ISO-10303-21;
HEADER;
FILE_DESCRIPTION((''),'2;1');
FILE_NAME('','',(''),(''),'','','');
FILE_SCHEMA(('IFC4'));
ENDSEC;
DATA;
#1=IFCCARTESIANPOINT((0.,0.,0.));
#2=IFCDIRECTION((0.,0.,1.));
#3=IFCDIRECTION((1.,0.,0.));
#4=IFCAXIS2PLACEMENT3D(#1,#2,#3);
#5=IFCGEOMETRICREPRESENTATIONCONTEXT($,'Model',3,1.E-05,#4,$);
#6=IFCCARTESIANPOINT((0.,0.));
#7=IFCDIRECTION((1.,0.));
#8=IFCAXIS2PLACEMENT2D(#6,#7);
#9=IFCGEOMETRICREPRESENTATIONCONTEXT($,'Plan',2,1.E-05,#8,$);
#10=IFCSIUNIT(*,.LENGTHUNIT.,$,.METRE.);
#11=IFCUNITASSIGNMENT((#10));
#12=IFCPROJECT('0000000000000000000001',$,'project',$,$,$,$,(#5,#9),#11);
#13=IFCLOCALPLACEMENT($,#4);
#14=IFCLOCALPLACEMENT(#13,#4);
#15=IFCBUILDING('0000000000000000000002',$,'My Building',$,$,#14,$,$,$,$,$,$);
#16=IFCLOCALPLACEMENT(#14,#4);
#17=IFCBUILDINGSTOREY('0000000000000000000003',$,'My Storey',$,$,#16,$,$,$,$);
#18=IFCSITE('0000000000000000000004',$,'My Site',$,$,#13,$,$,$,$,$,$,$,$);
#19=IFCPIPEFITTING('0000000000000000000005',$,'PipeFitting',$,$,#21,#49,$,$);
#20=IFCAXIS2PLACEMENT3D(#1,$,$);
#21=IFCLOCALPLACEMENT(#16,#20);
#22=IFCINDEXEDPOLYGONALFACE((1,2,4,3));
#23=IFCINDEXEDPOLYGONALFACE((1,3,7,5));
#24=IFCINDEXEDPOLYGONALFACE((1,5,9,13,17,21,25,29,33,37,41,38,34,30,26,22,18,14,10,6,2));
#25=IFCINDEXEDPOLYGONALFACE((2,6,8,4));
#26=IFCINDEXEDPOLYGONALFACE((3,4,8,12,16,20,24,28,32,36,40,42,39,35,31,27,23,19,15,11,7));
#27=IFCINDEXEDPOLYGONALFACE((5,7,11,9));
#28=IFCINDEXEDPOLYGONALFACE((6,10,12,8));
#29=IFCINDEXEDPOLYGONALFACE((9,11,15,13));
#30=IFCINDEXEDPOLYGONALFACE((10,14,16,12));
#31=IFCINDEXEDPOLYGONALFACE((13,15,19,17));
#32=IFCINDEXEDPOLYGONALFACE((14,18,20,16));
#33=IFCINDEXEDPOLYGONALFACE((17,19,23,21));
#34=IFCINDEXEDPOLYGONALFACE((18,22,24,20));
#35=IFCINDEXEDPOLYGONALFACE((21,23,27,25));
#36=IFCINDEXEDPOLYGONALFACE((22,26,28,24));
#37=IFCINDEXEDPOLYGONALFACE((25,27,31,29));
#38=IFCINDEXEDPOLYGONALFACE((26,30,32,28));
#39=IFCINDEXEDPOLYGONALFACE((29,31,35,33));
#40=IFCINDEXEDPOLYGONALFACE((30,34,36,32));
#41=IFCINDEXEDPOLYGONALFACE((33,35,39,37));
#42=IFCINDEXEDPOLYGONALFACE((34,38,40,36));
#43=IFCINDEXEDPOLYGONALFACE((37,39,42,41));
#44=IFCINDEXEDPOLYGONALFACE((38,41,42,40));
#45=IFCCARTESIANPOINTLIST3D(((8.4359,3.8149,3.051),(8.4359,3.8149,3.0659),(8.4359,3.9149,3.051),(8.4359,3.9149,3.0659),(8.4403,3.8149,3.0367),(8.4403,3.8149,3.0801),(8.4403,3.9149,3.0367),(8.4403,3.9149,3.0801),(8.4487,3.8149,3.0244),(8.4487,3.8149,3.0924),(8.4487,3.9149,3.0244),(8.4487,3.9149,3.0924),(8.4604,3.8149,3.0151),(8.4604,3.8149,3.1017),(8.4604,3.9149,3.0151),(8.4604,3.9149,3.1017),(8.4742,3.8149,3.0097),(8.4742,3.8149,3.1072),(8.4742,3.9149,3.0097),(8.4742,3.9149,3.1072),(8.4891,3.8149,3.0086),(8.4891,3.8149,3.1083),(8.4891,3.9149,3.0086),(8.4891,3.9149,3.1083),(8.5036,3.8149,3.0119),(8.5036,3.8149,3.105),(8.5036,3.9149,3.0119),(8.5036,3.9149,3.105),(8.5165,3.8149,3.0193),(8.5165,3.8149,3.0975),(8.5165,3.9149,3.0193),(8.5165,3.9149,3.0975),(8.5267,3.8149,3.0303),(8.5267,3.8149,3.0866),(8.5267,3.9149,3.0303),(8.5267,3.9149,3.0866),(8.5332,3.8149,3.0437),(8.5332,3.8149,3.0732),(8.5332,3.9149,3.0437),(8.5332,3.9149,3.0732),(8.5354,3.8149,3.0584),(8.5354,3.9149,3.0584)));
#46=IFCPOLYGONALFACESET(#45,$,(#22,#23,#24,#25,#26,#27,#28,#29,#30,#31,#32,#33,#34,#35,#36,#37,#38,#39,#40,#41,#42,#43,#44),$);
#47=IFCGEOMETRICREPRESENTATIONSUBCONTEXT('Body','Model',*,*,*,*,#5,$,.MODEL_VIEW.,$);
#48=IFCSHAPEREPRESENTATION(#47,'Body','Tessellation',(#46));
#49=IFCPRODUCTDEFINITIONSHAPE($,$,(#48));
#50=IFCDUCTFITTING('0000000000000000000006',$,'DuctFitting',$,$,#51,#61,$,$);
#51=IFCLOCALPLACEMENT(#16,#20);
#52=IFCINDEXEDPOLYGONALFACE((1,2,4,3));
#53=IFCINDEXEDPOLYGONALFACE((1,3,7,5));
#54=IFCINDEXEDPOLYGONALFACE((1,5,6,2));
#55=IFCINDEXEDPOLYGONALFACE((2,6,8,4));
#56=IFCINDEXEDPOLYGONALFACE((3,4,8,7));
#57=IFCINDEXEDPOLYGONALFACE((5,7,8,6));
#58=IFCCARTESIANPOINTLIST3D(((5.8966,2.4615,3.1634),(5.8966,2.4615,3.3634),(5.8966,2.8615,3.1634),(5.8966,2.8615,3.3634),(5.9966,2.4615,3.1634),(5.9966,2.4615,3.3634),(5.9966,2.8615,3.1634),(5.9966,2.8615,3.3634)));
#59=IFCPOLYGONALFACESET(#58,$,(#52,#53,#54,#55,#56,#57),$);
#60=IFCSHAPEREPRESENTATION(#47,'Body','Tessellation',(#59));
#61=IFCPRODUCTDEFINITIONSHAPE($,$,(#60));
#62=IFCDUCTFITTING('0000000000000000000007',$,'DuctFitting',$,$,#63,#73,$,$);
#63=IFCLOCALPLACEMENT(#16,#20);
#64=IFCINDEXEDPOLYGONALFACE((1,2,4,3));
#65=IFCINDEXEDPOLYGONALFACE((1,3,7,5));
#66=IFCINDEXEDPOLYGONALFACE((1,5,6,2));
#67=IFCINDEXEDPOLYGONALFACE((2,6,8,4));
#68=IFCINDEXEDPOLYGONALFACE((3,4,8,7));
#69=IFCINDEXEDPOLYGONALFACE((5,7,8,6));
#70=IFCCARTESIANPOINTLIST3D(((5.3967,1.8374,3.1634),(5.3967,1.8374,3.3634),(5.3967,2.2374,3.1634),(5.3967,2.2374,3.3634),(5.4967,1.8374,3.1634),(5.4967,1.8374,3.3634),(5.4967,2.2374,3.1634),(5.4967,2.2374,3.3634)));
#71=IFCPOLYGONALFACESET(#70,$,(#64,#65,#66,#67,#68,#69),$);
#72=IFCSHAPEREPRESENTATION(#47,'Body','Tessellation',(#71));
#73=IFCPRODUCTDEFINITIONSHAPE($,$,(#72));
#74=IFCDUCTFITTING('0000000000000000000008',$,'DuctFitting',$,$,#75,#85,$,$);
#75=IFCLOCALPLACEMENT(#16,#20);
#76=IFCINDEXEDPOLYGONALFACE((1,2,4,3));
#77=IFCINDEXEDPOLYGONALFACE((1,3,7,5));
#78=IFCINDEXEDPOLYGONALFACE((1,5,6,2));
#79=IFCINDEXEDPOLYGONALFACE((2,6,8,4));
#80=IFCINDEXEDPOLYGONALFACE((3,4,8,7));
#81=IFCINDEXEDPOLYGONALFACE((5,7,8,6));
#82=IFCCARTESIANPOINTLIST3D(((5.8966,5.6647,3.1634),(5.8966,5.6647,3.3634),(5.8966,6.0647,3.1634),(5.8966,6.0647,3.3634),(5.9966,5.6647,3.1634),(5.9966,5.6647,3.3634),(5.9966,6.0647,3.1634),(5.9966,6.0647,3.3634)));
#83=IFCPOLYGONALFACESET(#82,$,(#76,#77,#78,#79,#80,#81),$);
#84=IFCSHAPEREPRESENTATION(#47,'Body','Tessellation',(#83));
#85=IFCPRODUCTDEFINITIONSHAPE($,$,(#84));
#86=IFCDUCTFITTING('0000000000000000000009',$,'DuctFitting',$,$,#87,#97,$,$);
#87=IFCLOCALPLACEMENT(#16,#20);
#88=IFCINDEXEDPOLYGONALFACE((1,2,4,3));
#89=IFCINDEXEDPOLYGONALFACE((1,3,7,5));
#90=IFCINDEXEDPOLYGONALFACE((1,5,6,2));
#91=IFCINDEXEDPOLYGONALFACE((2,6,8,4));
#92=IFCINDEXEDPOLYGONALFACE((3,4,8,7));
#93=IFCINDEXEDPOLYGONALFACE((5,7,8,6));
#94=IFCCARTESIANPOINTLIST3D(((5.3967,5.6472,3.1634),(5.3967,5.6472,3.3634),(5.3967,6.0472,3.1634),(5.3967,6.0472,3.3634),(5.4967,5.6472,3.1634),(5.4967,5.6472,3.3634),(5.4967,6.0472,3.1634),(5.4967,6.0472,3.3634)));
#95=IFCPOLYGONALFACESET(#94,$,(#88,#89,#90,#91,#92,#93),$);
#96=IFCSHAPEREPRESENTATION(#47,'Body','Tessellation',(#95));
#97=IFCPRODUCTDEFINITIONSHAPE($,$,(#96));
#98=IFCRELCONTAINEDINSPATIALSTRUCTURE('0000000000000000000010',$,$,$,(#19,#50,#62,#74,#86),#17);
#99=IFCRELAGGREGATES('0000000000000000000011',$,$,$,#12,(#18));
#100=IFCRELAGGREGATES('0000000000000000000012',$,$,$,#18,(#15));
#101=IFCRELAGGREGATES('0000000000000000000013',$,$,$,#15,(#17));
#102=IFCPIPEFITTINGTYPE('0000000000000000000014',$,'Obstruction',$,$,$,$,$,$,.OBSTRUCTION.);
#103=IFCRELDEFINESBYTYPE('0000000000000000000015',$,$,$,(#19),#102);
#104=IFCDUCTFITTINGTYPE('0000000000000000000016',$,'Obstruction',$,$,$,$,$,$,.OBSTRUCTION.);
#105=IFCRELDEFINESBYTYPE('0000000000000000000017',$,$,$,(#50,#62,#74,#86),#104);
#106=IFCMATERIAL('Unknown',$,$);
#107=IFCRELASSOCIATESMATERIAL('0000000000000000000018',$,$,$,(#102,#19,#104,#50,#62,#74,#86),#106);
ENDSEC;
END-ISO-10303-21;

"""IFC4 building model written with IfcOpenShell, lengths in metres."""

from ifc_helpers import new_model, si_unit, frame, origin_with_axes, origin_2d_with_axis, place, context, subcontext, project, spatial, rectangle, circle, extrude, material, material_profile, profile_set, profile_usage, type_object, element, save


model = new_model("IFC4")

# Units and contexts
model_context = context("Model", 3, precision=1e-05, world=origin_with_axes())
plan_context = context("Plan", 2, precision=1e-05, world=origin_2d_with_axis())
body_context_1 = subcontext(model_context, "Body", "Model", "MODEL_VIEW")
ifc_project = project(units=[si_unit("LENGTHUNIT", "METRE")], contexts=[model_context, plan_context])

# Site, building, storey
site_placement = place(None, origin_with_axes())
site = spatial("IfcSite", under=ifc_project, at=site_placement, Name="My Site")
building_placement = place(site_placement, origin_with_axes())
building = spatial("IfcBuilding", under=site, at=building_placement, Name="My Building")
storey_placement = place(building_placement, origin_with_axes())
storey = spatial("IfcBuildingStorey", under=building, at=storey_placement, Name="My Storey")

# Shared definitions
ifc_material = material(Name="Unknown")

# Pipe fitting
ifc_material_profile_1 = material_profile(ifc_material, circle(Radius=0.05))
ifc_profile_set_1 = profile_set([ifc_material_profile_1])
pipe_fitting_type = type_object("IfcPipeFittingType", Name="Obstruction", PredefinedType="OBSTRUCTION", material=ifc_profile_set_1)
ifc_profile_usage_1 = profile_usage(ifc_profile_set_1, cardinal=5)
pipe_fitting_1_placement = place(storey_placement, frame((8.4854, 3.9149, 3.0584), z_axis=(0.0, -1.0, 0.000001), x_axis=(1.0, 0.0, 0.0)))
element("IfcPipeFitting", 1, at=pipe_fitting_1_placement, inside=storey, type_object=pipe_fitting_type, material=ifc_profile_usage_1, Name="PipeFitting", context=body_context_1, shape_type="SweptSolid", body=[
    extrude(circle(Radius=0.05), origin_with_axes(), (0.0, 0.0, 1.0), 0.1),
])

# Duct fittings
ifc_material_profile_2 = material_profile(ifc_material, rectangle(XDim=0.4, YDim=0.2))
ifc_profile_set_2 = profile_set([ifc_material_profile_2])
ifc_profile_usage_2 = profile_usage(ifc_profile_set_2, cardinal=5)
duct_fitting_type = type_object("IfcDuctFittingType", Name="Obstruction", PredefinedType="OBSTRUCTION", material=ifc_profile_set_2)
duct_fitting_1_placement = place(storey_placement, frame((5.9966, 2.6615, 3.2634), z_axis=(-1.0, 0.0, 0.0), x_axis=(0.0, -1.0, 0.0)))
element("IfcDuctFitting", 2, at=duct_fitting_1_placement, inside=storey, type_object=duct_fitting_type, material=ifc_profile_usage_2, Name="DuctFitting", context=body_context_1, shape_type="SweptSolid", body=[
    extrude(rectangle(XDim=0.4, YDim=0.2), origin_with_axes(), (0.0, 0.0, 1.0), 0.1),
])
ifc_profile_usage_3 = profile_usage(ifc_profile_set_2, cardinal=5)
duct_fitting_2_placement = place(storey_placement, frame((5.4967, 2.0374, 3.2634), z_axis=(-1.0, 0.0, 0.0), x_axis=(0.0, -1.0, 0.0)))
element("IfcDuctFitting", 3, at=duct_fitting_2_placement, inside=storey, type_object=duct_fitting_type, material=ifc_profile_usage_3, Name="DuctFitting", context=body_context_1, shape_type="SweptSolid", body=[
    extrude(rectangle(XDim=0.4, YDim=0.2), origin_with_axes(), (0.0, 0.0, 1.0), 0.1),
])
ifc_profile_usage_4 = profile_usage(ifc_profile_set_2, cardinal=5)
duct_fitting_3_placement = place(storey_placement, frame((5.9966, 5.8647, 3.2634), z_axis=(-1.0, 0.0, 0.0), x_axis=(0.0, -1.0, 0.0)))
element("IfcDuctFitting", 4, at=duct_fitting_3_placement, inside=storey, type_object=duct_fitting_type, material=ifc_profile_usage_4, Name="DuctFitting", context=body_context_1, shape_type="SweptSolid", body=[
    extrude(rectangle(XDim=0.4, YDim=0.2), origin_with_axes(), (0.0, 0.0, 1.0), 0.1),
])
ifc_profile_usage_5 = profile_usage(ifc_profile_set_2, cardinal=5)
duct_fitting_4_placement = place(storey_placement, frame((5.4967, 5.8472, 3.2634), z_axis=(-1.0, 0.0, 0.0), x_axis=(0.0, -1.0, 0.0)))
element("IfcDuctFitting", 5, at=duct_fitting_4_placement, inside=storey, type_object=duct_fitting_type, material=ifc_profile_usage_5, Name="DuctFitting", context=body_context_1, shape_type="SweptSolid", body=[
    extrude(rectangle(XDim=0.4, YDim=0.2), origin_with_axes(), (0.0, 0.0, 1.0), 0.1),
])

save(model, "model.ifc")
